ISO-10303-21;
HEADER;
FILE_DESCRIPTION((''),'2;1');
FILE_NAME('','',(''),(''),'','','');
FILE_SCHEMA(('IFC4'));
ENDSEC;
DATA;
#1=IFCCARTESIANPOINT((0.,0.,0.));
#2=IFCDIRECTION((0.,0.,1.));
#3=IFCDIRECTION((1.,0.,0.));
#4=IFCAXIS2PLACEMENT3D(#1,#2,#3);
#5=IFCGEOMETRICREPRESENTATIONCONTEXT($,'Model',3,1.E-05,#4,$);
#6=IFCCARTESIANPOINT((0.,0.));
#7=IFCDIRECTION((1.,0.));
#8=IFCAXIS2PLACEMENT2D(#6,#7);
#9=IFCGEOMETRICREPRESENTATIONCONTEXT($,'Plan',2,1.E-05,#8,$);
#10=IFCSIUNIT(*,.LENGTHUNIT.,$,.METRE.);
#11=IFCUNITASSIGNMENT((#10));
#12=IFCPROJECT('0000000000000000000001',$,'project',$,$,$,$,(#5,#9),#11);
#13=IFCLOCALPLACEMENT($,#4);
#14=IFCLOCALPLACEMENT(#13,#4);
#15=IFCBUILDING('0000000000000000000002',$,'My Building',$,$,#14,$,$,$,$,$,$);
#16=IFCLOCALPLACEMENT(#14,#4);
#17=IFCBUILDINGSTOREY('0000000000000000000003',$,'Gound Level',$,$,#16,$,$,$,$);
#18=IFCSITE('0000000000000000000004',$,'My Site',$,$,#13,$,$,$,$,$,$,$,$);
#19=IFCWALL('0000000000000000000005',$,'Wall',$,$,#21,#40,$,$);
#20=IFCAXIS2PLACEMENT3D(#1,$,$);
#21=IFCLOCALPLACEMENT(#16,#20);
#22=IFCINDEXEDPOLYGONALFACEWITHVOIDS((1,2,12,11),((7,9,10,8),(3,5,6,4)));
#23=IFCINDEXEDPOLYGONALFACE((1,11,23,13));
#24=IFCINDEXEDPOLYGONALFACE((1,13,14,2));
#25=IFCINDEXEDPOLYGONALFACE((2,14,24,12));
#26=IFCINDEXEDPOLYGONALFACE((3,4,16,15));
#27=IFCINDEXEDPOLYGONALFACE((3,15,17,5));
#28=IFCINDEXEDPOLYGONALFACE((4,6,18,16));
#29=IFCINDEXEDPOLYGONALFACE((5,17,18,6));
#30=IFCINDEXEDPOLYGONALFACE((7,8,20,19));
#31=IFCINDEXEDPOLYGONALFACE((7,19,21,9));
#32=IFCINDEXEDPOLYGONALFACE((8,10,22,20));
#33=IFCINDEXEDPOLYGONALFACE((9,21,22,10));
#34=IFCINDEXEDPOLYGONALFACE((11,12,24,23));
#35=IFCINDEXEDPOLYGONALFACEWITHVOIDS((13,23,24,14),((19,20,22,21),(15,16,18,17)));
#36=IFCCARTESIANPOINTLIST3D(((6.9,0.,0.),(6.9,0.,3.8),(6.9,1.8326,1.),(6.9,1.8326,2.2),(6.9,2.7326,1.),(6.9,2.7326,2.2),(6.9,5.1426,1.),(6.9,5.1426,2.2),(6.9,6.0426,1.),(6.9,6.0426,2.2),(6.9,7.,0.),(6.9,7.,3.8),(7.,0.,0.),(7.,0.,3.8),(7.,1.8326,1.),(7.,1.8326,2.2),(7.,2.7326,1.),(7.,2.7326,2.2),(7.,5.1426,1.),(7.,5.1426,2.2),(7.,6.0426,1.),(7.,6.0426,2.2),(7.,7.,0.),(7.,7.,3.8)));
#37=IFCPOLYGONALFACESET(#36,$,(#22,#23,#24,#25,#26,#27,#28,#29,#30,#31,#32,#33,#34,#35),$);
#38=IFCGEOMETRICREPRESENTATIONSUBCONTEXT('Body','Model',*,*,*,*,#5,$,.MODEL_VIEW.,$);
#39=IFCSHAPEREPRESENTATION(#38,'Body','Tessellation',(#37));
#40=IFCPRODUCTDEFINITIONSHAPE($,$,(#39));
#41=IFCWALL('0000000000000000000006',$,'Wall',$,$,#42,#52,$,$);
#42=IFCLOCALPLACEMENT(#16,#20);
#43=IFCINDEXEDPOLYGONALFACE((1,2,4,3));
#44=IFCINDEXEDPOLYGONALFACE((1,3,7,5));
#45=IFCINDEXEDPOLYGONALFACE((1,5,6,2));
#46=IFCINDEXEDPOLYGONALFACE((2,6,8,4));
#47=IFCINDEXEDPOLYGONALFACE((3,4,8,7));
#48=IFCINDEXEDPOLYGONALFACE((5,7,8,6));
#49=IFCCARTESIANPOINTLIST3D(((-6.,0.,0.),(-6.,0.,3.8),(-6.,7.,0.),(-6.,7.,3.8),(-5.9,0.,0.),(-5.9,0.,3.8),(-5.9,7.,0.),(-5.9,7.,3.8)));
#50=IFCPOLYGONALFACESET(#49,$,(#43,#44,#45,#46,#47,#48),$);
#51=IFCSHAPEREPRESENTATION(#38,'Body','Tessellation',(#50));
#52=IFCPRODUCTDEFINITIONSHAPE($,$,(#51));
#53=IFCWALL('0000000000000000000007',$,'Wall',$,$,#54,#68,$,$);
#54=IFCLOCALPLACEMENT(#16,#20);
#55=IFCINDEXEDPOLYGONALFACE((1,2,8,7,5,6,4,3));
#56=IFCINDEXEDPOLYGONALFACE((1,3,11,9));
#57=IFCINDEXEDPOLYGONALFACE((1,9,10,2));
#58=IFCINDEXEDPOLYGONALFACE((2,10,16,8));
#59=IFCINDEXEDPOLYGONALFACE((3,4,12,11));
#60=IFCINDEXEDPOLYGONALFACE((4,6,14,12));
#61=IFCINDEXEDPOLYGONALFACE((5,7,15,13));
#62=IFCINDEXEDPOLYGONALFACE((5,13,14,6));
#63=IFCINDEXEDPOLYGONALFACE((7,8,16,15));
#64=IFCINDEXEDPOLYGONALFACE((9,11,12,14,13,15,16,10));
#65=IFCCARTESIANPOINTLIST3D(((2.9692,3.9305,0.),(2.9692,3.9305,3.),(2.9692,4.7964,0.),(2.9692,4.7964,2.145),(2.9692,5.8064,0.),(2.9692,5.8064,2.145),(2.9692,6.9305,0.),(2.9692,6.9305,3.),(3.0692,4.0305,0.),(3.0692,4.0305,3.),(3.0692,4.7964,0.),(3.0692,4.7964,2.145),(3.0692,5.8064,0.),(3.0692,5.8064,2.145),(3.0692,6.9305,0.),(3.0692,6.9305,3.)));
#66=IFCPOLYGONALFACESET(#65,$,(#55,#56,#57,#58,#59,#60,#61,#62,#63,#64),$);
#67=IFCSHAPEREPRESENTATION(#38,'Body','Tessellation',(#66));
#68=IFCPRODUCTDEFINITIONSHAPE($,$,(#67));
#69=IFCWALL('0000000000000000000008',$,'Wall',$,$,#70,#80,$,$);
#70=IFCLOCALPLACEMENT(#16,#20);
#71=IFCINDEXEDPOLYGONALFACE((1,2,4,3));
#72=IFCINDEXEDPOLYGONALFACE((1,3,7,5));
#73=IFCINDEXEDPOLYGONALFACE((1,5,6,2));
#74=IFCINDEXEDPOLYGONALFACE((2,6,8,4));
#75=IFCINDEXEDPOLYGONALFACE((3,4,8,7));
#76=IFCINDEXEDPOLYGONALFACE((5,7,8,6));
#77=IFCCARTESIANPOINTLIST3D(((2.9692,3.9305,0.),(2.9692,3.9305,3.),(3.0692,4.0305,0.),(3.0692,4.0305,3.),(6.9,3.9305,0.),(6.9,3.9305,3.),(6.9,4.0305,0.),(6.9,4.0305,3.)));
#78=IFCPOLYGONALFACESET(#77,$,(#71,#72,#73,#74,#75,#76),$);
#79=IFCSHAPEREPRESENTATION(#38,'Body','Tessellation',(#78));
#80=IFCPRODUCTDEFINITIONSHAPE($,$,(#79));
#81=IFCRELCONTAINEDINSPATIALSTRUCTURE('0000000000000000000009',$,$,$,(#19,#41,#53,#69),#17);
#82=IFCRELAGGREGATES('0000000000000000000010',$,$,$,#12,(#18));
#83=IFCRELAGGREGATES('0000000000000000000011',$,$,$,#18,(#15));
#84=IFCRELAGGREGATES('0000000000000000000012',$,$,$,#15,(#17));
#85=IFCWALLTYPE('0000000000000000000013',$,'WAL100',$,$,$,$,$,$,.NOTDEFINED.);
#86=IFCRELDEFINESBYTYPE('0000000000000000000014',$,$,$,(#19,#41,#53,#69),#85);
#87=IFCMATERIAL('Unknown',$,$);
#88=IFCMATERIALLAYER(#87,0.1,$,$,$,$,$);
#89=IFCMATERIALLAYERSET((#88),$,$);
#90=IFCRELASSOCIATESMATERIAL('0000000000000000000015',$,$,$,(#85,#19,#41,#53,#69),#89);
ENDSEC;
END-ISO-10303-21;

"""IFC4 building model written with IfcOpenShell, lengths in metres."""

from ifc_helpers import new_model, si_unit, frame, origin_with_axes, origin_2d_with_axis, place, context, subcontext, project, spatial, line, indexed_curve, outline, extrude, source, transform, mapped, material, layer, layer_set, layer_usage, type_object, element, save


model = new_model("IFC4")

# Units and contexts
model_context = context("Model", 3, precision=1e-05, world=origin_with_axes())
plan_context = context("Plan", 2, precision=1e-05, world=origin_2d_with_axis())
body_context = subcontext(model_context, "Body", "Model", "MODEL_VIEW")
ifc_project = project(units=[si_unit("LENGTHUNIT", "METRE")], contexts=[model_context, plan_context])

# Site, building, storey
site_placement = place(None, origin_with_axes())
site = spatial("IfcSite", under=ifc_project, at=site_placement, Name="My Site")
building_placement = place(site_placement, origin_with_axes())
building = spatial("IfcBuilding", under=site, at=building_placement, Name="My Building")
storey_placement = place(building_placement, origin_with_axes())
storey = spatial("IfcBuildingStorey", under=building, at=storey_placement, Name="Gound Level")

# Wall, openings
ifc_material = material(Name="Unknown")
ifc_layer = layer(ifc_material, 0.1)
ifc_layer_set = layer_set([ifc_layer])
ifc_layer_usage_1 = layer_usage(ifc_layer_set, "AXIS2", "POSITIVE", 0.0)
wall_type = type_object("IfcWallType", Name="WAL100", PredefinedType="NOTDEFINED", material=ifc_layer_set)
wall_1_placement = place(storey_placement, frame((7.0, 0.0, 0.0), z_axis=(0.0, 0.0, 1.0), x_axis=(0.0, 1.0, 0.0)))
wall_1 = element("IfcWall", 1, at=wall_1_placement, inside=storey, type_object=wall_type, material=ifc_layer_usage_1, Name="Wall", context=body_context, shape_type="SweptSolid", body=[
    extrude(outline(indexed_curve([(0.0, 0.0), (0.0, 0.1), (7.0, 0.1), (7.0, 0.0)], segments=[line(1, 2, 3, 4, 1)])), origin_with_axes(), (0.0, 0.0, 1.0), 3.8),
])
shared_shape_1 = source(origin_with_axes(), body_context, "Body", "SweptSolid", [
    extrude(outline(indexed_curve([(0.0, 0.0), (0.9, 0.0), (0.9, 1.2), (0.0, 1.2)], segments=[line(1, 2, 3, 4, 1)])), frame((0.0, -0.6, 0.0), z_axis=(0.0, -1.0, 0.0), x_axis=(1.0, 0.0, 0.0)), (0.0, 0.0, -1.0), 1.2),
])
opening_1_placement = place(wall_1_placement, frame((2.7326, 0.1, 1.0), z_axis=(0.0, 0.0, 1.0), x_axis=(-1.0, 0.0, 0.0)))
element("IfcOpeningElement", 2, at=opening_1_placement, cuts=wall_1, PredefinedType="OPENING", context=body_context, shape_type="MappedRepresentation", body=[
    mapped(shared_shape_1, transform((0.0, 0.0, 0.0), x_axis=(1.0, 0.0, 0.0), y_axis=(0.0, 1.0, 0.0), z_axis=(0.0, 0.0, 1.0), scale=1.0)),
])
opening_2_placement = place(wall_1_placement, frame((6.0426, 0.1, 1.0), z_axis=(0.0, 0.0, 1.0), x_axis=(-1.0, 0.0, 0.0)))
element("IfcOpeningElement", 3, at=opening_2_placement, cuts=wall_1, PredefinedType="OPENING", context=body_context, shape_type="MappedRepresentation", body=[
    mapped(shared_shape_1, transform((0.0, 0.0, 0.0), x_axis=(1.0, 0.0, 0.0), y_axis=(0.0, 1.0, 0.0), z_axis=(0.0, 0.0, 1.0), scale=1.0)),
])

# Wall
ifc_layer_usage_2 = layer_usage(ifc_layer_set, "AXIS2", "POSITIVE", 0.0)
wall_2_placement = place(storey_placement, frame((-6.0, 7.0, 0.0), z_axis=(0.0, 0.0, 1.0), x_axis=(0.0, -1.0, 0.0)))
element("IfcWall", 4, at=wall_2_placement, inside=storey, type_object=wall_type, material=ifc_layer_usage_2, Name="Wall", context=body_context, shape_type="SweptSolid", body=[
    extrude(outline(indexed_curve([(0.0, 0.0), (0.0, 0.1), (7.0, 0.1), (7.0, 0.0)], segments=[line(1, 2, 3, 4, 1)])), origin_with_axes(), (0.0, 0.0, 1.0), 3.8),
])

# Wall, opening
ifc_layer_usage_3 = layer_usage(ifc_layer_set, "AXIS2", "POSITIVE", 0.0)
wall_3_placement = place(storey_placement, frame((2.9692, 6.9305, 0.0), z_axis=(0.0, 0.0, 1.0), x_axis=(0.0, -1.0, 0.0)))
wall_3 = element("IfcWall", 5, at=wall_3_placement, inside=storey, type_object=wall_type, material=ifc_layer_usage_3, Name="Wall", context=body_context, shape_type="SweptSolid", body=[
    extrude(outline(indexed_curve([(0.0, 0.0), (0.0, 0.1), (2.9, 0.1), (3.0, 0.0)], segments=[line(1, 2, 3, 4, 1)])), origin_with_axes(), (0.0, 0.0, 1.0), 3.0),
])
shared_shape_2 = source(origin_with_axes(), body_context, "Body", "SweptSolid", [
    extrude(outline(indexed_curve([(0.0, 0.0), (1.01, 0.0), (1.01, 2.145), (0.0, 2.145)], segments=[line(1, 2, 3, 4, 1)])), frame((0.0, -0.6, 0.0), z_axis=(0.0, -1.0, 0.0), x_axis=(1.0, 0.0, 0.0)), (0.0, 0.0, -1.0), 1.2),
])
opening_3_placement = place(wall_3_placement, frame((2.134, 0.1, 0.0), z_axis=(0.0, 0.0, 1.0), x_axis=(-1.0, 0.0, 0.0)))
element("IfcOpeningElement", 6, at=opening_3_placement, cuts=wall_3, PredefinedType="OPENING", context=body_context, shape_type="MappedRepresentation", body=[
    mapped(shared_shape_2, transform((0.0, 0.0, 0.0), x_axis=(1.0, 0.0, 0.0), y_axis=(0.0, 1.0, 0.0), z_axis=(0.0, 0.0, 1.0), scale=1.0)),
])

# Wall
ifc_layer_usage_4 = layer_usage(ifc_layer_set, "AXIS2", "POSITIVE", 0.0)
wall_4_placement = place(storey_placement, frame((2.9692, 3.9305, 0.0), z_axis=(0.0, 0.0, 1.0), x_axis=(1.0, 0.0, 0.0)))
element("IfcWall", 7, at=wall_4_placement, inside=storey, type_object=wall_type, material=ifc_layer_usage_4, Name="Wall", context=body_context, shape_type="SweptSolid", body=[
    extrude(outline(indexed_curve([(0.0, 0.0), (0.1, 0.1), (3.9308, 0.1), (3.9308, 0.0)], segments=[line(1, 2, 3, 4, 1)])), origin_with_axes(), (0.0, 0.0, 1.0), 3.0),
])

save(model, "model.ifc")
